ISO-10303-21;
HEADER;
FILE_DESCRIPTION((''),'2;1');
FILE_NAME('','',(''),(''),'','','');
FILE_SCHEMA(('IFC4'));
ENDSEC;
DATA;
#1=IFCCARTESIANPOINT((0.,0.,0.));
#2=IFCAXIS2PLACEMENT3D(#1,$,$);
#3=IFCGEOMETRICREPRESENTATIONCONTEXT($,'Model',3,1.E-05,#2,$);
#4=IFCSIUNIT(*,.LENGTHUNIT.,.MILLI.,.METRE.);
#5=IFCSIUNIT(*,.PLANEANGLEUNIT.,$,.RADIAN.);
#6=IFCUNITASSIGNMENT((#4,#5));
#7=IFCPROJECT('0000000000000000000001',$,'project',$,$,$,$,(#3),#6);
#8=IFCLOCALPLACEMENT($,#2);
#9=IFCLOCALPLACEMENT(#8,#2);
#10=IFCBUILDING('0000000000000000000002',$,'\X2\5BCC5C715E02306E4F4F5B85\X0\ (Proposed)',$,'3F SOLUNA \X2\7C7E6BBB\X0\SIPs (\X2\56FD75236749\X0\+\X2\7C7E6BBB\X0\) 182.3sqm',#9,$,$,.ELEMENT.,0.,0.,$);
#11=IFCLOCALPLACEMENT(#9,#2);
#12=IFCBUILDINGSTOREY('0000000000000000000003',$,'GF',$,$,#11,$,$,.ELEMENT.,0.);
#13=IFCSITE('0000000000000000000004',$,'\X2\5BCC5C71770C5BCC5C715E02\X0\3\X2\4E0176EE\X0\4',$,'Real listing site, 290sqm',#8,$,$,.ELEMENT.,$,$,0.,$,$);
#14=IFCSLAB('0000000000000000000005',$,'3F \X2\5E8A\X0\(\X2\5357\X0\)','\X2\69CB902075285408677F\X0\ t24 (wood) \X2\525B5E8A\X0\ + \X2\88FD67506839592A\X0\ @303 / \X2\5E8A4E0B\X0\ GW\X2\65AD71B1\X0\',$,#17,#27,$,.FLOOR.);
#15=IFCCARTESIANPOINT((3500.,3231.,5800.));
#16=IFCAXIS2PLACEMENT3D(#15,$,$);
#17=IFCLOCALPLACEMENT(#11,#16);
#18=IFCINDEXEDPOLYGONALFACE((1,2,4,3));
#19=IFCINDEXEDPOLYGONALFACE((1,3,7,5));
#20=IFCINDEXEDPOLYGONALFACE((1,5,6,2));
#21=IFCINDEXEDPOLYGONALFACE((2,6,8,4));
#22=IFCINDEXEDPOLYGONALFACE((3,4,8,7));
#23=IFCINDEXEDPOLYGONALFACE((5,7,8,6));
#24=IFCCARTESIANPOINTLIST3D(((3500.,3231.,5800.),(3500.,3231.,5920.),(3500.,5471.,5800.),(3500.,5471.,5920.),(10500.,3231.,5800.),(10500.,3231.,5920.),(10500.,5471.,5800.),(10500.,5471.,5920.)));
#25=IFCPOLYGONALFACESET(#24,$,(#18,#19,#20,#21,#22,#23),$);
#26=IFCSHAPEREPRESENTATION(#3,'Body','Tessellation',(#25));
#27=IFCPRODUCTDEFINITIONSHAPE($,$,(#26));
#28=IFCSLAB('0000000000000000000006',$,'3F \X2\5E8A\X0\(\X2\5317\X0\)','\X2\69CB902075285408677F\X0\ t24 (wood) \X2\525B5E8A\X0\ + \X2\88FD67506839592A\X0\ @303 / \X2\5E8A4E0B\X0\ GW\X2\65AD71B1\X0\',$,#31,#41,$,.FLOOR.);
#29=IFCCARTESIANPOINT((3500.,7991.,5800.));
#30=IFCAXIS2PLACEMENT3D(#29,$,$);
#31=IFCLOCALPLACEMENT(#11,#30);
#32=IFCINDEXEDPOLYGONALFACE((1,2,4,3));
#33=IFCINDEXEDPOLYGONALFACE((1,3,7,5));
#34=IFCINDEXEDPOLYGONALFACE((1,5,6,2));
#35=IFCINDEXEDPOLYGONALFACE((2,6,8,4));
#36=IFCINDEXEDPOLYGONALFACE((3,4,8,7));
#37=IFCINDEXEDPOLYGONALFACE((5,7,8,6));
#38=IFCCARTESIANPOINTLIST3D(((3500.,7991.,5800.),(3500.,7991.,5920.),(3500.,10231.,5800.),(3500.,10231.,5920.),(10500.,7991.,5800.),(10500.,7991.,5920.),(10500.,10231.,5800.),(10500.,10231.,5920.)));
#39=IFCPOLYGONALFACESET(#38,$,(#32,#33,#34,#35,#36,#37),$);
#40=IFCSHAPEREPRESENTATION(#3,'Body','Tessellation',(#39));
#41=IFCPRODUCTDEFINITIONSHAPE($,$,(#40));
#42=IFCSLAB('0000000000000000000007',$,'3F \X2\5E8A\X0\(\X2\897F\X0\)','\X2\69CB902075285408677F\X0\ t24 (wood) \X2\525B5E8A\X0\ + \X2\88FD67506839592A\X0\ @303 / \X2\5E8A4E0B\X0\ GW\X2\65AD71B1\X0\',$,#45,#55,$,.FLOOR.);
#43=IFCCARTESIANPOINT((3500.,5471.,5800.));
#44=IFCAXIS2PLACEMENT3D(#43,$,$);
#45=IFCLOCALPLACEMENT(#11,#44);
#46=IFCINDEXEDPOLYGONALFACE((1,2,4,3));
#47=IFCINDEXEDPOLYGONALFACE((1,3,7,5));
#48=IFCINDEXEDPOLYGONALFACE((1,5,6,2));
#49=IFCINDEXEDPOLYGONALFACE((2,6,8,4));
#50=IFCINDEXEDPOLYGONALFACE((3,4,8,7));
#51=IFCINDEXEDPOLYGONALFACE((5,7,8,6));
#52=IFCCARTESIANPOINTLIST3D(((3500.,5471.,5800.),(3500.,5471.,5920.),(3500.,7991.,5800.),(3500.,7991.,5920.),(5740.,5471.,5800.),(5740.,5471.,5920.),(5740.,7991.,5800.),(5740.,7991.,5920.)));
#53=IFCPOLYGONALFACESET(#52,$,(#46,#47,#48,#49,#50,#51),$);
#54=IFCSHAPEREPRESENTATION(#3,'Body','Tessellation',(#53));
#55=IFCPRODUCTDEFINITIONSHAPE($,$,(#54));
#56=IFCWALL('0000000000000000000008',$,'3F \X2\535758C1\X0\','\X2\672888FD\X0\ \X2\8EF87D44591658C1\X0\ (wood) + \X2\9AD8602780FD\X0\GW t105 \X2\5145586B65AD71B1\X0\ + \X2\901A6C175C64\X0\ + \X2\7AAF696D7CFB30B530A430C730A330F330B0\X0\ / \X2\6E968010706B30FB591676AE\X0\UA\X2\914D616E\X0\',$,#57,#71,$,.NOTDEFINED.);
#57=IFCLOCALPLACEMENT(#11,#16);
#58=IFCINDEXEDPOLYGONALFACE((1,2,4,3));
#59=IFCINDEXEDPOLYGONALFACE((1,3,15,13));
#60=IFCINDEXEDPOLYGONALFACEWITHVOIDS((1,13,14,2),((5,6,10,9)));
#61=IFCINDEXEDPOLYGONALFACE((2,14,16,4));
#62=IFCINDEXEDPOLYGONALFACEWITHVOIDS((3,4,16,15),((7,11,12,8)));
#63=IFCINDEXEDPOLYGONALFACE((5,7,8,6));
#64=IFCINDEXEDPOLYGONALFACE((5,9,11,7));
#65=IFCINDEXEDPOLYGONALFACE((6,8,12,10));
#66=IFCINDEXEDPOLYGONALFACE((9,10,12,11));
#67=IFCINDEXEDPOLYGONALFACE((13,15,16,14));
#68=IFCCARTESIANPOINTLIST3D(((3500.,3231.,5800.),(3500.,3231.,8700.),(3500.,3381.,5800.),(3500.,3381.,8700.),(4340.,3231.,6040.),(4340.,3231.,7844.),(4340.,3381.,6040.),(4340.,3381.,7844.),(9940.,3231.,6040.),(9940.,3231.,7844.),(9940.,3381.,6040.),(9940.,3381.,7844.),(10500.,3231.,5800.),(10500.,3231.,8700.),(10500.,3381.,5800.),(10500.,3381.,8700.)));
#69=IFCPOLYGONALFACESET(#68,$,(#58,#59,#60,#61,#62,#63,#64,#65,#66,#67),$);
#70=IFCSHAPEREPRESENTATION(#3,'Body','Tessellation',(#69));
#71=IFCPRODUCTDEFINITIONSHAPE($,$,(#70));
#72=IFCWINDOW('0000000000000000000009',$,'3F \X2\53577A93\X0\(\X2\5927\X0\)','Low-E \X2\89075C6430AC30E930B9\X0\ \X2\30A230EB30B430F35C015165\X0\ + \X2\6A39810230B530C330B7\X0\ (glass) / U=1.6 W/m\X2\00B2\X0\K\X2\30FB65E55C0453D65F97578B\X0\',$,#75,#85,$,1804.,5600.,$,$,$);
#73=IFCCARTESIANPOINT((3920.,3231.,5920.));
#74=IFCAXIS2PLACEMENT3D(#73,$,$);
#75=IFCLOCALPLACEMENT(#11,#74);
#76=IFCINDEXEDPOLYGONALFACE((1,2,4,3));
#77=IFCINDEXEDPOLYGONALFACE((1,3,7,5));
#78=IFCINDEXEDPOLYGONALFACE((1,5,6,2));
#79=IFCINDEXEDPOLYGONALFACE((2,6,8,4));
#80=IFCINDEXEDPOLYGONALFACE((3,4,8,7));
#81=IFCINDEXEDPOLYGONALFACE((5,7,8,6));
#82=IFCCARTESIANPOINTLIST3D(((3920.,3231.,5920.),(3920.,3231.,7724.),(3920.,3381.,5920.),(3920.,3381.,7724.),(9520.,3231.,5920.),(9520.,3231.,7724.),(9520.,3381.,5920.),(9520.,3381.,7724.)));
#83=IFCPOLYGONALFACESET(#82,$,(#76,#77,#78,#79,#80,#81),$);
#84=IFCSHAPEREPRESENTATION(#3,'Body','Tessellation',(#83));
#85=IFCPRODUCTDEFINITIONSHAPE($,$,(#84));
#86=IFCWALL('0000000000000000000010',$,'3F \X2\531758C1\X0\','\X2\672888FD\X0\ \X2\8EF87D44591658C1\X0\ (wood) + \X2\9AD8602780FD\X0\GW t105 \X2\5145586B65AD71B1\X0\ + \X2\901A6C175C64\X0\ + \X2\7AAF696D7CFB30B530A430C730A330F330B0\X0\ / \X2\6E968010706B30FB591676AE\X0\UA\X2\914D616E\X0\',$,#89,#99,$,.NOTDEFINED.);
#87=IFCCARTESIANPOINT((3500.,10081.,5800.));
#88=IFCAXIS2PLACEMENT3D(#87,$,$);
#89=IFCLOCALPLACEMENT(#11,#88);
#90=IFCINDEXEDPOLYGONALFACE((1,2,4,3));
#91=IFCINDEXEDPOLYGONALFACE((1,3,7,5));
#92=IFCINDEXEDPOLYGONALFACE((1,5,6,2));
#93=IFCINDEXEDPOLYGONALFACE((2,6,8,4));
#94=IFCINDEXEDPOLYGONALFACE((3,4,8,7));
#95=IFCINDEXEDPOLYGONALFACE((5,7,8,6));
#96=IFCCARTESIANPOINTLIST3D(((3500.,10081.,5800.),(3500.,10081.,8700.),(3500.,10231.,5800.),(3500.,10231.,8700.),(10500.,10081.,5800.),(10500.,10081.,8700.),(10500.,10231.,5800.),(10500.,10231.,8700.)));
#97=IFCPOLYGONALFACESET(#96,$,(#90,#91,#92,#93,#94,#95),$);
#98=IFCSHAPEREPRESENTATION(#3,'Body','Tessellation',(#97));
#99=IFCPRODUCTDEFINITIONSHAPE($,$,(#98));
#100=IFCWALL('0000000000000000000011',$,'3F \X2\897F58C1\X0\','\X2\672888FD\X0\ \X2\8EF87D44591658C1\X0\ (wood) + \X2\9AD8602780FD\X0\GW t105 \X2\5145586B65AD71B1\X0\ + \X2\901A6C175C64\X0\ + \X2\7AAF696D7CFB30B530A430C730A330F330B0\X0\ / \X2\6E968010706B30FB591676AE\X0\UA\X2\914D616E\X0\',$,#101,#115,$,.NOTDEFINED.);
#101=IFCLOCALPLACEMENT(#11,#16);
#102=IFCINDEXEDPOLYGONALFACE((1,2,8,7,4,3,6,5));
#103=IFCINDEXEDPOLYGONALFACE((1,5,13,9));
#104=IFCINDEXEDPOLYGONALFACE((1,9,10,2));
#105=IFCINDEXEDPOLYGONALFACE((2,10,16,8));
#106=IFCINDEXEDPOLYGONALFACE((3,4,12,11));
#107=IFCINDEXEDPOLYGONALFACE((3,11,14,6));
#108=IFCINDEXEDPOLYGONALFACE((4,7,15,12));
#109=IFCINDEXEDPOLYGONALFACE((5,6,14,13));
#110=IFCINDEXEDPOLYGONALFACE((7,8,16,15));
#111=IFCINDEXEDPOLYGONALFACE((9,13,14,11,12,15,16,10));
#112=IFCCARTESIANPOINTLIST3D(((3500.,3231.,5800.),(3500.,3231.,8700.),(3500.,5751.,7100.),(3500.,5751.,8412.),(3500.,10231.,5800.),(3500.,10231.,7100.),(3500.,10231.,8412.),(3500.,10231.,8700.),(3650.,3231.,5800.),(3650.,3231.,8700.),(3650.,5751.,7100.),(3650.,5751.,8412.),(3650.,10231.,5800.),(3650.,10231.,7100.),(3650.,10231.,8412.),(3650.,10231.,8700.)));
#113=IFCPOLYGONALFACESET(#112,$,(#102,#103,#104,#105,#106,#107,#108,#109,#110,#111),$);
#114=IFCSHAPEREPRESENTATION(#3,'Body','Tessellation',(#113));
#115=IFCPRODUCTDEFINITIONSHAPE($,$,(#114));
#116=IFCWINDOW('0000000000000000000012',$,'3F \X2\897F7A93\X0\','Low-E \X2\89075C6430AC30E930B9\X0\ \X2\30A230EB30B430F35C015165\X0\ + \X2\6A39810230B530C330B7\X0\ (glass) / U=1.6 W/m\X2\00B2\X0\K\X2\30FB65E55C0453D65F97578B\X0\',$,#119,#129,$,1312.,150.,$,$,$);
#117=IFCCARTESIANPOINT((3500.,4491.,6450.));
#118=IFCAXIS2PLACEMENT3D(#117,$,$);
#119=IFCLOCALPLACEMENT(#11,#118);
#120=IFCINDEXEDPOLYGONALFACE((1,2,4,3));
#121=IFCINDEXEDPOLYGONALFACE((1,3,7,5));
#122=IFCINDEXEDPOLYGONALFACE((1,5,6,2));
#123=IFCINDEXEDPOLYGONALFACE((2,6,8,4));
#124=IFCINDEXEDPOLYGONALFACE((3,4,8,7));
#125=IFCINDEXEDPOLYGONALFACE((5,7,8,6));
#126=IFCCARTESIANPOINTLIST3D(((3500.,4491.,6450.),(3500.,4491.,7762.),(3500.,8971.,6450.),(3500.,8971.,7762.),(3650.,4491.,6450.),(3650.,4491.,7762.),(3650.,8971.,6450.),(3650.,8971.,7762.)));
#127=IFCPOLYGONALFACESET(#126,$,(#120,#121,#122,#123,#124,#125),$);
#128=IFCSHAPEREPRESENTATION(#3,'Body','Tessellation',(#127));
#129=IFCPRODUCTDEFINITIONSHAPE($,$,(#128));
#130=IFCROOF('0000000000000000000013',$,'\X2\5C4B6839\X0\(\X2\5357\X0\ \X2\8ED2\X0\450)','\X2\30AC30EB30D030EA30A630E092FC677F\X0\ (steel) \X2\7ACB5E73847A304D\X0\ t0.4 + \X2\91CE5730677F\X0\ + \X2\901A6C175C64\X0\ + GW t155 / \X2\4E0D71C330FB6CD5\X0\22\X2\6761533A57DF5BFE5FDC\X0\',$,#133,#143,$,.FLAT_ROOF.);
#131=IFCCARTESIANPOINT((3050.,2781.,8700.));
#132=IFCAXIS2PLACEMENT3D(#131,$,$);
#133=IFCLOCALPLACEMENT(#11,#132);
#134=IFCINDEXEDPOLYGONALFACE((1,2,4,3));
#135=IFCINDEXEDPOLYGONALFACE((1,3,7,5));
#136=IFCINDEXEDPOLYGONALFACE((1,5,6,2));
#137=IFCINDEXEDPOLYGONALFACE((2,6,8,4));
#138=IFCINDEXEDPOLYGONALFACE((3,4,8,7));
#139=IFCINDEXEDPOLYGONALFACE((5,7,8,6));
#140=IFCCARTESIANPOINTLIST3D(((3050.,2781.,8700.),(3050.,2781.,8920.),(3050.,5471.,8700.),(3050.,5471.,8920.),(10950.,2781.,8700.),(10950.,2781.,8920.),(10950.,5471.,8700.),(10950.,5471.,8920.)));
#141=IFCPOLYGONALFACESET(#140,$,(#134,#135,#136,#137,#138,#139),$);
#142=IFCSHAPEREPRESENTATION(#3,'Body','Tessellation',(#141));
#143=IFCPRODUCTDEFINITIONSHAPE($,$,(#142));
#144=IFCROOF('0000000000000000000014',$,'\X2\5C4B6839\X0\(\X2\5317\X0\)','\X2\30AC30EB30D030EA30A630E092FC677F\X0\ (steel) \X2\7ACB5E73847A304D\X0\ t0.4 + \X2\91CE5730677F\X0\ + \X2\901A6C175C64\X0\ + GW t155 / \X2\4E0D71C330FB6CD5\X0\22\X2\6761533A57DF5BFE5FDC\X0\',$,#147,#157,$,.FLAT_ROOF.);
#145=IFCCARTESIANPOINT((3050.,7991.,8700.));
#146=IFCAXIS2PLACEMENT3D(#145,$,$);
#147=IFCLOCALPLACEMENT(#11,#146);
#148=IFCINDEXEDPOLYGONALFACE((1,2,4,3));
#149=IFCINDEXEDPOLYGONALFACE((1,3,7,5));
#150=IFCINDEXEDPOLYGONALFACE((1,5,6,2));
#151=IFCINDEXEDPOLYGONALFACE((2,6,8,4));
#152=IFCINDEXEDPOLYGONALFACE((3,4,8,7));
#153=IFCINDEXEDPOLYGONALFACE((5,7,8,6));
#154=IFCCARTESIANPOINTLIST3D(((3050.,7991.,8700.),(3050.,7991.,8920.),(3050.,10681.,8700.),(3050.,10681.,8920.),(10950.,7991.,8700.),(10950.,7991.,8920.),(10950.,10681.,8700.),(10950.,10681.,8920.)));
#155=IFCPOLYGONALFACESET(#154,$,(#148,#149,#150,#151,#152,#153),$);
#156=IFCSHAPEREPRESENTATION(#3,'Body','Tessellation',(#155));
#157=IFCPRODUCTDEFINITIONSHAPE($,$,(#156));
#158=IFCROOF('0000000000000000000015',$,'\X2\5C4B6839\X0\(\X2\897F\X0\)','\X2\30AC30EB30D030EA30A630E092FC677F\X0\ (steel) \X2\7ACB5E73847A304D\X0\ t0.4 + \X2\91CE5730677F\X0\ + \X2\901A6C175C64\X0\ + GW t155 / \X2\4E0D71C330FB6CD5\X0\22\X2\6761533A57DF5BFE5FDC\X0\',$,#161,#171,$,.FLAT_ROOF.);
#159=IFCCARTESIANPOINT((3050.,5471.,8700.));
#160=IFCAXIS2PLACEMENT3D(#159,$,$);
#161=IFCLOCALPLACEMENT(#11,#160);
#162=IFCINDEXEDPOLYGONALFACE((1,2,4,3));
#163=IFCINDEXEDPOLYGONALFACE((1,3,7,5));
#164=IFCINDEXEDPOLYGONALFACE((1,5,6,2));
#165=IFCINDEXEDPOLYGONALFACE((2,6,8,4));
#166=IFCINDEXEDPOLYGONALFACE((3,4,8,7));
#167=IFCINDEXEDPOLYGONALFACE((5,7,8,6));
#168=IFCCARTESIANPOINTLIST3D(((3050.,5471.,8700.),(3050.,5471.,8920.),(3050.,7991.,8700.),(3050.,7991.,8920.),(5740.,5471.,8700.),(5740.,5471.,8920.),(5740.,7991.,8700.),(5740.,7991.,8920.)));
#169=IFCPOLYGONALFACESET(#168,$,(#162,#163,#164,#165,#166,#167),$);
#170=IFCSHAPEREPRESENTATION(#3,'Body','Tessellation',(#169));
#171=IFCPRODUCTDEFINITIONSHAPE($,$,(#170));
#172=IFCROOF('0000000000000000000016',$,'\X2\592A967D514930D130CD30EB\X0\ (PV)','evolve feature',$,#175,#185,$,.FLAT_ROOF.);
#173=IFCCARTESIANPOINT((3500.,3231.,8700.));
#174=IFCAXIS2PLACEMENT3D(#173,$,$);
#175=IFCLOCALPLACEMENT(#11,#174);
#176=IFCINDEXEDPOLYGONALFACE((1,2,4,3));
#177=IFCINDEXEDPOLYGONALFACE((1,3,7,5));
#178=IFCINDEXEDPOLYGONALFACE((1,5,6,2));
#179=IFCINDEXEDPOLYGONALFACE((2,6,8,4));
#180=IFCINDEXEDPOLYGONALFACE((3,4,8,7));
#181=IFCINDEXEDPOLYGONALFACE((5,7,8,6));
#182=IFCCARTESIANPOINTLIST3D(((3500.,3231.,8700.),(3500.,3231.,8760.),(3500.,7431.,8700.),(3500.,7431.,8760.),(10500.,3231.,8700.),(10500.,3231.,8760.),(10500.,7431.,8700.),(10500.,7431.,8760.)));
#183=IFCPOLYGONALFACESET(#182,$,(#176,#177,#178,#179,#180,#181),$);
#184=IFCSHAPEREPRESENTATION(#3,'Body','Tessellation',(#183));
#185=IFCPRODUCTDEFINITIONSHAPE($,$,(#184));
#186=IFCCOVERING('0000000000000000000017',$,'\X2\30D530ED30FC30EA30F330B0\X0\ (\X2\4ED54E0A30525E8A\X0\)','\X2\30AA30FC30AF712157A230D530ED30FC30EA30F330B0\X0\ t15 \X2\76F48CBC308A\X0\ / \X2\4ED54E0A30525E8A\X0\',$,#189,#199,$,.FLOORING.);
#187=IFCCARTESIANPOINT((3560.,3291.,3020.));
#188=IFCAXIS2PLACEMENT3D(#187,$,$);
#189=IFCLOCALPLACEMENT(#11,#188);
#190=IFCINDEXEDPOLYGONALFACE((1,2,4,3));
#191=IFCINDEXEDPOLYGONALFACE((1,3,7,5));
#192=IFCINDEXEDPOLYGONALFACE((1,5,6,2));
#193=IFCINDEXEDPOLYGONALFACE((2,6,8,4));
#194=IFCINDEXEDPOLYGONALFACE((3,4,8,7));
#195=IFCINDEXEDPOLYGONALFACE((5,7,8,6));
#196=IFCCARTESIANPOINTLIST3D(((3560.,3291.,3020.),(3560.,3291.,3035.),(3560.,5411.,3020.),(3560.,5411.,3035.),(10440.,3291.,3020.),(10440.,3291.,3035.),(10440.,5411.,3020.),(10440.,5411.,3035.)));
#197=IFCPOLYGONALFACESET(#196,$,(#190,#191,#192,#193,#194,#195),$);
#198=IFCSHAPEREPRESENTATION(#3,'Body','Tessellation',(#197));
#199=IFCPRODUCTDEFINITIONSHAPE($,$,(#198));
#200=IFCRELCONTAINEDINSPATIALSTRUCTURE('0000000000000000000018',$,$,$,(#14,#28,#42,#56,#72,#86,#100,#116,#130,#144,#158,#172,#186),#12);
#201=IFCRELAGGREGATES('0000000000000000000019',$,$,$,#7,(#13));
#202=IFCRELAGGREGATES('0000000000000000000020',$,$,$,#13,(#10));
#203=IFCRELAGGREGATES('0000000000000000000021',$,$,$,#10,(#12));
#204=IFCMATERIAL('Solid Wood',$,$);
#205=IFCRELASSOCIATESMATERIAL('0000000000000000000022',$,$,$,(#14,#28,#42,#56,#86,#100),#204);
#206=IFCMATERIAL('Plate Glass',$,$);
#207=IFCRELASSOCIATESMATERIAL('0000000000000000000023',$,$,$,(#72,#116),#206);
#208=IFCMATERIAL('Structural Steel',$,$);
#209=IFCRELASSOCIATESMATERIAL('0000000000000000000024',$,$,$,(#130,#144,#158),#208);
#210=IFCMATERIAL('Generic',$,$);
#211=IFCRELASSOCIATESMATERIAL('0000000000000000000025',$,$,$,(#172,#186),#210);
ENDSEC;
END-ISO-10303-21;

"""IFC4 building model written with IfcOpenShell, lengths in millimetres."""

from ifc_helpers import new_model, si_unit, frame, frame_2d, origin, place, context, project, spatial, rectangle, extrude, material, element, fill, save


model = new_model("IFC4")

# Units and contexts
model_context = context("Model", 3, precision=1e-05, world=origin())
ifc_project = project(units=[si_unit("LENGTHUNIT", "METRE", prefix="MILLI"), si_unit("PLANEANGLEUNIT", "RADIAN")], contexts=[model_context])

# Site, building, storey
site_placement = place(None, origin())
site = spatial("IfcSite", under=ifc_project, at=site_placement, Name="富山県富山市3丁目4", ObjectType="Real listing site, 290sqm", CompositionType="ELEMENT", RefElevation=0.0)
building_placement = place(site_placement, origin())
building = spatial("IfcBuilding", under=site, at=building_placement, Name="富山市の住宅 (Proposed)", ObjectType="3F SOLUNA 籾殻SIPs (国産杉+籾殻) 182.3sqm", CompositionType="ELEMENT", ElevationOfRefHeight=0.0, ElevationOfTerrain=0.0)
storey_placement = place(building_placement, origin())
storey = spatial("IfcBuildingStorey", under=building, at=storey_placement, Name="GF", CompositionType="ELEMENT", Elevation=0.0)

# Slabs
ifc_material_1 = material(Name="Solid Wood")
slab_1_placement = place(storey_placement, frame((3500.0, 3231.0, 5800.0)))
element("IfcSlab", 1, at=slab_1_placement, inside=storey, material=ifc_material_1, Name="3F 床(南)", Description="構造用合板 t24 (wood) 剛床 + 製材根太 @303 / 床下 GW断熱", PredefinedType="FLOOR", context=model_context, shape_type="SweptSolid", body=[
    extrude(rectangle(XDim=7000.0, YDim=2240.0, at=frame_2d((3500.0, 1120.0))), frame((3500.0, 3231.0, 5800.0)), (0.0, 0.0, 1.0), 120.0),
])
slab_2_placement = place(storey_placement, frame((3500.0, 7991.0, 5800.0)))
element("IfcSlab", 2, at=slab_2_placement, inside=storey, material=ifc_material_1, Name="3F 床(北)", Description="構造用合板 t24 (wood) 剛床 + 製材根太 @303 / 床下 GW断熱", PredefinedType="FLOOR", context=model_context, shape_type="SweptSolid", body=[
    extrude(rectangle(XDim=7000.0, YDim=2240.0, at=frame_2d((3500.0, 1120.0))), frame((3500.0, 7991.0, 5800.0)), (0.0, 0.0, 1.0), 120.0),
])
slab_3_placement = place(storey_placement, frame((3500.0, 5471.0, 5800.0)))
element("IfcSlab", 3, at=slab_3_placement, inside=storey, material=ifc_material_1, Name="3F 床(西)", Description="構造用合板 t24 (wood) 剛床 + 製材根太 @303 / 床下 GW断熱", PredefinedType="FLOOR", context=model_context, shape_type="SweptSolid", body=[
    extrude(rectangle(XDim=2240.0, YDim=2520.0, at=frame_2d((1120.0, 1260.0))), frame((3500.0, 5471.0, 5800.0)), (0.0, 0.0, 1.0), 120.0),
])

# Wall, opening, window
wall_1_placement = place(storey_placement, frame((3500.0, 3231.0, 5800.0)))
wall_1 = element("IfcWall", 4, at=wall_1_placement, inside=storey, material=ifc_material_1, Name="3F 南壁", Description="木製 軸組外壁 (wood) + 高性能GW t105 充填断熱 + 通気層 + 窯業系サイディング / 準耐火・外皮UA配慮", PredefinedType="NOTDEFINED", context=model_context, shape_type="SweptSolid", body=[
    extrude(rectangle(XDim=7000.0, YDim=150.0, at=frame_2d((3500.0, 75.0))), frame((3500.0, 3231.0, 5800.0)), (0.0, 0.0, 1.0), 2900.0),
])
opening_1_placement = place(storey_placement, frame((3920.0, 3231.0, 5920.0)))
opening_1 = element("IfcOpeningElement", 5, at=opening_1_placement, cuts=wall_1, PredefinedType="NOTDEFINED", context=model_context, shape_type="SweptSolid", body=[
    extrude(rectangle(XDim=5600.0, YDim=150.0, at=frame_2d((2800.0, 75.0))), frame((3920.0, 3231.0, 5920.0)), (0.0, 0.0, 1.0), 1804.0),
])
ifc_material_2 = material(Name="Plate Glass")
window_1_placement = place(storey_placement, frame((3920.0, 3231.0, 5920.0)))
window_1 = element("IfcWindow", 6, at=window_1_placement, inside=storey, material=ifc_material_2, Name="3F 南窓(大)", Description="Low-E 複層ガラス アルゴン封入 + 樹脂サッシ (glass) / U=1.6 W/m²K・日射取得型", OverallHeight=1804.0, OverallWidth=5600.0, context=model_context, shape_type="SweptSolid", body=[
    extrude(rectangle(XDim=5600.0, YDim=150.0, at=frame_2d((2800.0, 75.0))), frame((3920.0, 3231.0, 5920.0)), (0.0, 0.0, 1.0), 1804.0),
])
fill(opening_1, window_1)

# Wall
wall_2_placement = place(storey_placement, frame((3500.0, 10081.0, 5800.0)))
element("IfcWall", 7, at=wall_2_placement, inside=storey, material=ifc_material_1, Name="3F 北壁", Description="木製 軸組外壁 (wood) + 高性能GW t105 充填断熱 + 通気層 + 窯業系サイディング / 準耐火・外皮UA配慮", PredefinedType="NOTDEFINED", context=model_context, shape_type="SweptSolid", body=[
    extrude(rectangle(XDim=7000.0, YDim=150.0, at=frame_2d((3500.0, 75.0))), frame((3500.0, 10081.0, 5800.0)), (0.0, 0.0, 1.0), 2900.0),
])

# Wall, opening, window
wall_3_placement = place(storey_placement, frame((3500.0, 3231.0, 5800.0)))
wall_3 = element("IfcWall", 8, at=wall_3_placement, inside=storey, material=ifc_material_1, Name="3F 西壁", Description="木製 軸組外壁 (wood) + 高性能GW t105 充填断熱 + 通気層 + 窯業系サイディング / 準耐火・外皮UA配慮", PredefinedType="NOTDEFINED", context=model_context, shape_type="SweptSolid", body=[
    extrude(rectangle(XDim=150.0, YDim=7000.0, at=frame_2d((75.0, 3500.0))), frame((3500.0, 3231.0, 5800.0)), (0.0, 0.0, 1.0), 2900.0),
])
opening_2_placement = place(storey_placement, frame((3500.0, 4491.0, 6450.0)))
opening_2 = element("IfcOpeningElement", 9, at=opening_2_placement, cuts=wall_3, PredefinedType="NOTDEFINED", context=model_context, shape_type="SweptSolid", body=[
    extrude(rectangle(XDim=150.0, YDim=4480.0, at=frame_2d((75.0, 2240.0))), frame((3500.0, 4491.0, 6450.0)), (0.0, 0.0, 1.0), 1312.0),
])
window_2_placement = place(storey_placement, frame((3500.0, 4491.0, 6450.0)))
window_2 = element("IfcWindow", 10, at=window_2_placement, inside=storey, material=ifc_material_2, Name="3F 西窓", Description="Low-E 複層ガラス アルゴン封入 + 樹脂サッシ (glass) / U=1.6 W/m²K・日射取得型", OverallHeight=1312.0, OverallWidth=150.0, context=model_context, shape_type="SweptSolid", body=[
    extrude(rectangle(XDim=150.0, YDim=4480.0, at=frame_2d((75.0, 2240.0))), frame((3500.0, 4491.0, 6450.0)), (0.0, 0.0, 1.0), 1312.0),
])
fill(opening_2, window_2)

# Roofs
ifc_material_3 = material(Name="Structural Steel")
roof_1_placement = place(storey_placement, frame((3050.0, 2781.0, 8700.0)))
element("IfcRoof", 11, at=roof_1_placement, inside=storey, material=ifc_material_3, Name="屋根(南 軒450)", Description="ガルバリウム鋼板 (steel) 立平葺き t0.4 + 野地板 + 通気層 + GW t155 / 不燃・法22条区域対応", PredefinedType="FLAT_ROOF", context=model_context, shape_type="SweptSolid", body=[
    extrude(rectangle(XDim=7900.0, YDim=2690.0, at=frame_2d((3950.0, 1345.0))), frame((3050.0, 2781.0, 8700.0)), (0.0, 0.0, 1.0), 220.0),
])
roof_2_placement = place(storey_placement, frame((3050.0, 7991.0, 8700.0)))
element("IfcRoof", 12, at=roof_2_placement, inside=storey, material=ifc_material_3, Name="屋根(北)", Description="ガルバリウム鋼板 (steel) 立平葺き t0.4 + 野地板 + 通気層 + GW t155 / 不燃・法22条区域対応", PredefinedType="FLAT_ROOF", context=model_context, shape_type="SweptSolid", body=[
    extrude(rectangle(XDim=7900.0, YDim=2690.0, at=frame_2d((3950.0, 1345.0))), frame((3050.0, 7991.0, 8700.0)), (0.0, 0.0, 1.0), 220.0),
])
roof_3_placement = place(storey_placement, frame((3050.0, 5471.0, 8700.0)))
element("IfcRoof", 13, at=roof_3_placement, inside=storey, material=ifc_material_3, Name="屋根(西)", Description="ガルバリウム鋼板 (steel) 立平葺き t0.4 + 野地板 + 通気層 + GW t155 / 不燃・法22条区域対応", PredefinedType="FLAT_ROOF", context=model_context, shape_type="SweptSolid", body=[
    extrude(rectangle(XDim=2690.0, YDim=2520.0, at=frame_2d((1345.0, 1260.0))), frame((3050.0, 5471.0, 8700.0)), (0.0, 0.0, 1.0), 220.0),
])
ifc_material_4 = material(Name="Generic")
roof_4_placement = place(storey_placement, frame((3500.0, 3231.0, 8700.0)))
element("IfcRoof", 14, at=roof_4_placement, inside=storey, material=ifc_material_4, Name="太陽光パネル (PV)", Description="evolve feature", PredefinedType="FLAT_ROOF", context=model_context, shape_type="SweptSolid", body=[
    extrude(rectangle(XDim=7000.0, YDim=4200.0, at=frame_2d((3500.0, 2100.0))), frame((3500.0, 3231.0, 8700.0)), (0.0, 0.0, 1.0), 60.0),
])

# Covering
covering_1_placement = place(storey_placement, frame((3560.0, 3291.0, 3020.0)))
element("IfcCovering", 15, at=covering_1_placement, inside=storey, material=ifc_material_4, Name="フローリング (仕上げ床)", Description="オーク無垢フローリング t15 直貼り / 仕上げ床", PredefinedType="FLOORING", context=model_context, shape_type="SweptSolid", body=[
    extrude(rectangle(XDim=6880.0, YDim=2120.0, at=frame_2d((3440.0, 1060.0))), frame((3560.0, 3291.0, 3020.0)), (0.0, 0.0, 1.0), 15.0),
])

save(model, "model.ifc")
